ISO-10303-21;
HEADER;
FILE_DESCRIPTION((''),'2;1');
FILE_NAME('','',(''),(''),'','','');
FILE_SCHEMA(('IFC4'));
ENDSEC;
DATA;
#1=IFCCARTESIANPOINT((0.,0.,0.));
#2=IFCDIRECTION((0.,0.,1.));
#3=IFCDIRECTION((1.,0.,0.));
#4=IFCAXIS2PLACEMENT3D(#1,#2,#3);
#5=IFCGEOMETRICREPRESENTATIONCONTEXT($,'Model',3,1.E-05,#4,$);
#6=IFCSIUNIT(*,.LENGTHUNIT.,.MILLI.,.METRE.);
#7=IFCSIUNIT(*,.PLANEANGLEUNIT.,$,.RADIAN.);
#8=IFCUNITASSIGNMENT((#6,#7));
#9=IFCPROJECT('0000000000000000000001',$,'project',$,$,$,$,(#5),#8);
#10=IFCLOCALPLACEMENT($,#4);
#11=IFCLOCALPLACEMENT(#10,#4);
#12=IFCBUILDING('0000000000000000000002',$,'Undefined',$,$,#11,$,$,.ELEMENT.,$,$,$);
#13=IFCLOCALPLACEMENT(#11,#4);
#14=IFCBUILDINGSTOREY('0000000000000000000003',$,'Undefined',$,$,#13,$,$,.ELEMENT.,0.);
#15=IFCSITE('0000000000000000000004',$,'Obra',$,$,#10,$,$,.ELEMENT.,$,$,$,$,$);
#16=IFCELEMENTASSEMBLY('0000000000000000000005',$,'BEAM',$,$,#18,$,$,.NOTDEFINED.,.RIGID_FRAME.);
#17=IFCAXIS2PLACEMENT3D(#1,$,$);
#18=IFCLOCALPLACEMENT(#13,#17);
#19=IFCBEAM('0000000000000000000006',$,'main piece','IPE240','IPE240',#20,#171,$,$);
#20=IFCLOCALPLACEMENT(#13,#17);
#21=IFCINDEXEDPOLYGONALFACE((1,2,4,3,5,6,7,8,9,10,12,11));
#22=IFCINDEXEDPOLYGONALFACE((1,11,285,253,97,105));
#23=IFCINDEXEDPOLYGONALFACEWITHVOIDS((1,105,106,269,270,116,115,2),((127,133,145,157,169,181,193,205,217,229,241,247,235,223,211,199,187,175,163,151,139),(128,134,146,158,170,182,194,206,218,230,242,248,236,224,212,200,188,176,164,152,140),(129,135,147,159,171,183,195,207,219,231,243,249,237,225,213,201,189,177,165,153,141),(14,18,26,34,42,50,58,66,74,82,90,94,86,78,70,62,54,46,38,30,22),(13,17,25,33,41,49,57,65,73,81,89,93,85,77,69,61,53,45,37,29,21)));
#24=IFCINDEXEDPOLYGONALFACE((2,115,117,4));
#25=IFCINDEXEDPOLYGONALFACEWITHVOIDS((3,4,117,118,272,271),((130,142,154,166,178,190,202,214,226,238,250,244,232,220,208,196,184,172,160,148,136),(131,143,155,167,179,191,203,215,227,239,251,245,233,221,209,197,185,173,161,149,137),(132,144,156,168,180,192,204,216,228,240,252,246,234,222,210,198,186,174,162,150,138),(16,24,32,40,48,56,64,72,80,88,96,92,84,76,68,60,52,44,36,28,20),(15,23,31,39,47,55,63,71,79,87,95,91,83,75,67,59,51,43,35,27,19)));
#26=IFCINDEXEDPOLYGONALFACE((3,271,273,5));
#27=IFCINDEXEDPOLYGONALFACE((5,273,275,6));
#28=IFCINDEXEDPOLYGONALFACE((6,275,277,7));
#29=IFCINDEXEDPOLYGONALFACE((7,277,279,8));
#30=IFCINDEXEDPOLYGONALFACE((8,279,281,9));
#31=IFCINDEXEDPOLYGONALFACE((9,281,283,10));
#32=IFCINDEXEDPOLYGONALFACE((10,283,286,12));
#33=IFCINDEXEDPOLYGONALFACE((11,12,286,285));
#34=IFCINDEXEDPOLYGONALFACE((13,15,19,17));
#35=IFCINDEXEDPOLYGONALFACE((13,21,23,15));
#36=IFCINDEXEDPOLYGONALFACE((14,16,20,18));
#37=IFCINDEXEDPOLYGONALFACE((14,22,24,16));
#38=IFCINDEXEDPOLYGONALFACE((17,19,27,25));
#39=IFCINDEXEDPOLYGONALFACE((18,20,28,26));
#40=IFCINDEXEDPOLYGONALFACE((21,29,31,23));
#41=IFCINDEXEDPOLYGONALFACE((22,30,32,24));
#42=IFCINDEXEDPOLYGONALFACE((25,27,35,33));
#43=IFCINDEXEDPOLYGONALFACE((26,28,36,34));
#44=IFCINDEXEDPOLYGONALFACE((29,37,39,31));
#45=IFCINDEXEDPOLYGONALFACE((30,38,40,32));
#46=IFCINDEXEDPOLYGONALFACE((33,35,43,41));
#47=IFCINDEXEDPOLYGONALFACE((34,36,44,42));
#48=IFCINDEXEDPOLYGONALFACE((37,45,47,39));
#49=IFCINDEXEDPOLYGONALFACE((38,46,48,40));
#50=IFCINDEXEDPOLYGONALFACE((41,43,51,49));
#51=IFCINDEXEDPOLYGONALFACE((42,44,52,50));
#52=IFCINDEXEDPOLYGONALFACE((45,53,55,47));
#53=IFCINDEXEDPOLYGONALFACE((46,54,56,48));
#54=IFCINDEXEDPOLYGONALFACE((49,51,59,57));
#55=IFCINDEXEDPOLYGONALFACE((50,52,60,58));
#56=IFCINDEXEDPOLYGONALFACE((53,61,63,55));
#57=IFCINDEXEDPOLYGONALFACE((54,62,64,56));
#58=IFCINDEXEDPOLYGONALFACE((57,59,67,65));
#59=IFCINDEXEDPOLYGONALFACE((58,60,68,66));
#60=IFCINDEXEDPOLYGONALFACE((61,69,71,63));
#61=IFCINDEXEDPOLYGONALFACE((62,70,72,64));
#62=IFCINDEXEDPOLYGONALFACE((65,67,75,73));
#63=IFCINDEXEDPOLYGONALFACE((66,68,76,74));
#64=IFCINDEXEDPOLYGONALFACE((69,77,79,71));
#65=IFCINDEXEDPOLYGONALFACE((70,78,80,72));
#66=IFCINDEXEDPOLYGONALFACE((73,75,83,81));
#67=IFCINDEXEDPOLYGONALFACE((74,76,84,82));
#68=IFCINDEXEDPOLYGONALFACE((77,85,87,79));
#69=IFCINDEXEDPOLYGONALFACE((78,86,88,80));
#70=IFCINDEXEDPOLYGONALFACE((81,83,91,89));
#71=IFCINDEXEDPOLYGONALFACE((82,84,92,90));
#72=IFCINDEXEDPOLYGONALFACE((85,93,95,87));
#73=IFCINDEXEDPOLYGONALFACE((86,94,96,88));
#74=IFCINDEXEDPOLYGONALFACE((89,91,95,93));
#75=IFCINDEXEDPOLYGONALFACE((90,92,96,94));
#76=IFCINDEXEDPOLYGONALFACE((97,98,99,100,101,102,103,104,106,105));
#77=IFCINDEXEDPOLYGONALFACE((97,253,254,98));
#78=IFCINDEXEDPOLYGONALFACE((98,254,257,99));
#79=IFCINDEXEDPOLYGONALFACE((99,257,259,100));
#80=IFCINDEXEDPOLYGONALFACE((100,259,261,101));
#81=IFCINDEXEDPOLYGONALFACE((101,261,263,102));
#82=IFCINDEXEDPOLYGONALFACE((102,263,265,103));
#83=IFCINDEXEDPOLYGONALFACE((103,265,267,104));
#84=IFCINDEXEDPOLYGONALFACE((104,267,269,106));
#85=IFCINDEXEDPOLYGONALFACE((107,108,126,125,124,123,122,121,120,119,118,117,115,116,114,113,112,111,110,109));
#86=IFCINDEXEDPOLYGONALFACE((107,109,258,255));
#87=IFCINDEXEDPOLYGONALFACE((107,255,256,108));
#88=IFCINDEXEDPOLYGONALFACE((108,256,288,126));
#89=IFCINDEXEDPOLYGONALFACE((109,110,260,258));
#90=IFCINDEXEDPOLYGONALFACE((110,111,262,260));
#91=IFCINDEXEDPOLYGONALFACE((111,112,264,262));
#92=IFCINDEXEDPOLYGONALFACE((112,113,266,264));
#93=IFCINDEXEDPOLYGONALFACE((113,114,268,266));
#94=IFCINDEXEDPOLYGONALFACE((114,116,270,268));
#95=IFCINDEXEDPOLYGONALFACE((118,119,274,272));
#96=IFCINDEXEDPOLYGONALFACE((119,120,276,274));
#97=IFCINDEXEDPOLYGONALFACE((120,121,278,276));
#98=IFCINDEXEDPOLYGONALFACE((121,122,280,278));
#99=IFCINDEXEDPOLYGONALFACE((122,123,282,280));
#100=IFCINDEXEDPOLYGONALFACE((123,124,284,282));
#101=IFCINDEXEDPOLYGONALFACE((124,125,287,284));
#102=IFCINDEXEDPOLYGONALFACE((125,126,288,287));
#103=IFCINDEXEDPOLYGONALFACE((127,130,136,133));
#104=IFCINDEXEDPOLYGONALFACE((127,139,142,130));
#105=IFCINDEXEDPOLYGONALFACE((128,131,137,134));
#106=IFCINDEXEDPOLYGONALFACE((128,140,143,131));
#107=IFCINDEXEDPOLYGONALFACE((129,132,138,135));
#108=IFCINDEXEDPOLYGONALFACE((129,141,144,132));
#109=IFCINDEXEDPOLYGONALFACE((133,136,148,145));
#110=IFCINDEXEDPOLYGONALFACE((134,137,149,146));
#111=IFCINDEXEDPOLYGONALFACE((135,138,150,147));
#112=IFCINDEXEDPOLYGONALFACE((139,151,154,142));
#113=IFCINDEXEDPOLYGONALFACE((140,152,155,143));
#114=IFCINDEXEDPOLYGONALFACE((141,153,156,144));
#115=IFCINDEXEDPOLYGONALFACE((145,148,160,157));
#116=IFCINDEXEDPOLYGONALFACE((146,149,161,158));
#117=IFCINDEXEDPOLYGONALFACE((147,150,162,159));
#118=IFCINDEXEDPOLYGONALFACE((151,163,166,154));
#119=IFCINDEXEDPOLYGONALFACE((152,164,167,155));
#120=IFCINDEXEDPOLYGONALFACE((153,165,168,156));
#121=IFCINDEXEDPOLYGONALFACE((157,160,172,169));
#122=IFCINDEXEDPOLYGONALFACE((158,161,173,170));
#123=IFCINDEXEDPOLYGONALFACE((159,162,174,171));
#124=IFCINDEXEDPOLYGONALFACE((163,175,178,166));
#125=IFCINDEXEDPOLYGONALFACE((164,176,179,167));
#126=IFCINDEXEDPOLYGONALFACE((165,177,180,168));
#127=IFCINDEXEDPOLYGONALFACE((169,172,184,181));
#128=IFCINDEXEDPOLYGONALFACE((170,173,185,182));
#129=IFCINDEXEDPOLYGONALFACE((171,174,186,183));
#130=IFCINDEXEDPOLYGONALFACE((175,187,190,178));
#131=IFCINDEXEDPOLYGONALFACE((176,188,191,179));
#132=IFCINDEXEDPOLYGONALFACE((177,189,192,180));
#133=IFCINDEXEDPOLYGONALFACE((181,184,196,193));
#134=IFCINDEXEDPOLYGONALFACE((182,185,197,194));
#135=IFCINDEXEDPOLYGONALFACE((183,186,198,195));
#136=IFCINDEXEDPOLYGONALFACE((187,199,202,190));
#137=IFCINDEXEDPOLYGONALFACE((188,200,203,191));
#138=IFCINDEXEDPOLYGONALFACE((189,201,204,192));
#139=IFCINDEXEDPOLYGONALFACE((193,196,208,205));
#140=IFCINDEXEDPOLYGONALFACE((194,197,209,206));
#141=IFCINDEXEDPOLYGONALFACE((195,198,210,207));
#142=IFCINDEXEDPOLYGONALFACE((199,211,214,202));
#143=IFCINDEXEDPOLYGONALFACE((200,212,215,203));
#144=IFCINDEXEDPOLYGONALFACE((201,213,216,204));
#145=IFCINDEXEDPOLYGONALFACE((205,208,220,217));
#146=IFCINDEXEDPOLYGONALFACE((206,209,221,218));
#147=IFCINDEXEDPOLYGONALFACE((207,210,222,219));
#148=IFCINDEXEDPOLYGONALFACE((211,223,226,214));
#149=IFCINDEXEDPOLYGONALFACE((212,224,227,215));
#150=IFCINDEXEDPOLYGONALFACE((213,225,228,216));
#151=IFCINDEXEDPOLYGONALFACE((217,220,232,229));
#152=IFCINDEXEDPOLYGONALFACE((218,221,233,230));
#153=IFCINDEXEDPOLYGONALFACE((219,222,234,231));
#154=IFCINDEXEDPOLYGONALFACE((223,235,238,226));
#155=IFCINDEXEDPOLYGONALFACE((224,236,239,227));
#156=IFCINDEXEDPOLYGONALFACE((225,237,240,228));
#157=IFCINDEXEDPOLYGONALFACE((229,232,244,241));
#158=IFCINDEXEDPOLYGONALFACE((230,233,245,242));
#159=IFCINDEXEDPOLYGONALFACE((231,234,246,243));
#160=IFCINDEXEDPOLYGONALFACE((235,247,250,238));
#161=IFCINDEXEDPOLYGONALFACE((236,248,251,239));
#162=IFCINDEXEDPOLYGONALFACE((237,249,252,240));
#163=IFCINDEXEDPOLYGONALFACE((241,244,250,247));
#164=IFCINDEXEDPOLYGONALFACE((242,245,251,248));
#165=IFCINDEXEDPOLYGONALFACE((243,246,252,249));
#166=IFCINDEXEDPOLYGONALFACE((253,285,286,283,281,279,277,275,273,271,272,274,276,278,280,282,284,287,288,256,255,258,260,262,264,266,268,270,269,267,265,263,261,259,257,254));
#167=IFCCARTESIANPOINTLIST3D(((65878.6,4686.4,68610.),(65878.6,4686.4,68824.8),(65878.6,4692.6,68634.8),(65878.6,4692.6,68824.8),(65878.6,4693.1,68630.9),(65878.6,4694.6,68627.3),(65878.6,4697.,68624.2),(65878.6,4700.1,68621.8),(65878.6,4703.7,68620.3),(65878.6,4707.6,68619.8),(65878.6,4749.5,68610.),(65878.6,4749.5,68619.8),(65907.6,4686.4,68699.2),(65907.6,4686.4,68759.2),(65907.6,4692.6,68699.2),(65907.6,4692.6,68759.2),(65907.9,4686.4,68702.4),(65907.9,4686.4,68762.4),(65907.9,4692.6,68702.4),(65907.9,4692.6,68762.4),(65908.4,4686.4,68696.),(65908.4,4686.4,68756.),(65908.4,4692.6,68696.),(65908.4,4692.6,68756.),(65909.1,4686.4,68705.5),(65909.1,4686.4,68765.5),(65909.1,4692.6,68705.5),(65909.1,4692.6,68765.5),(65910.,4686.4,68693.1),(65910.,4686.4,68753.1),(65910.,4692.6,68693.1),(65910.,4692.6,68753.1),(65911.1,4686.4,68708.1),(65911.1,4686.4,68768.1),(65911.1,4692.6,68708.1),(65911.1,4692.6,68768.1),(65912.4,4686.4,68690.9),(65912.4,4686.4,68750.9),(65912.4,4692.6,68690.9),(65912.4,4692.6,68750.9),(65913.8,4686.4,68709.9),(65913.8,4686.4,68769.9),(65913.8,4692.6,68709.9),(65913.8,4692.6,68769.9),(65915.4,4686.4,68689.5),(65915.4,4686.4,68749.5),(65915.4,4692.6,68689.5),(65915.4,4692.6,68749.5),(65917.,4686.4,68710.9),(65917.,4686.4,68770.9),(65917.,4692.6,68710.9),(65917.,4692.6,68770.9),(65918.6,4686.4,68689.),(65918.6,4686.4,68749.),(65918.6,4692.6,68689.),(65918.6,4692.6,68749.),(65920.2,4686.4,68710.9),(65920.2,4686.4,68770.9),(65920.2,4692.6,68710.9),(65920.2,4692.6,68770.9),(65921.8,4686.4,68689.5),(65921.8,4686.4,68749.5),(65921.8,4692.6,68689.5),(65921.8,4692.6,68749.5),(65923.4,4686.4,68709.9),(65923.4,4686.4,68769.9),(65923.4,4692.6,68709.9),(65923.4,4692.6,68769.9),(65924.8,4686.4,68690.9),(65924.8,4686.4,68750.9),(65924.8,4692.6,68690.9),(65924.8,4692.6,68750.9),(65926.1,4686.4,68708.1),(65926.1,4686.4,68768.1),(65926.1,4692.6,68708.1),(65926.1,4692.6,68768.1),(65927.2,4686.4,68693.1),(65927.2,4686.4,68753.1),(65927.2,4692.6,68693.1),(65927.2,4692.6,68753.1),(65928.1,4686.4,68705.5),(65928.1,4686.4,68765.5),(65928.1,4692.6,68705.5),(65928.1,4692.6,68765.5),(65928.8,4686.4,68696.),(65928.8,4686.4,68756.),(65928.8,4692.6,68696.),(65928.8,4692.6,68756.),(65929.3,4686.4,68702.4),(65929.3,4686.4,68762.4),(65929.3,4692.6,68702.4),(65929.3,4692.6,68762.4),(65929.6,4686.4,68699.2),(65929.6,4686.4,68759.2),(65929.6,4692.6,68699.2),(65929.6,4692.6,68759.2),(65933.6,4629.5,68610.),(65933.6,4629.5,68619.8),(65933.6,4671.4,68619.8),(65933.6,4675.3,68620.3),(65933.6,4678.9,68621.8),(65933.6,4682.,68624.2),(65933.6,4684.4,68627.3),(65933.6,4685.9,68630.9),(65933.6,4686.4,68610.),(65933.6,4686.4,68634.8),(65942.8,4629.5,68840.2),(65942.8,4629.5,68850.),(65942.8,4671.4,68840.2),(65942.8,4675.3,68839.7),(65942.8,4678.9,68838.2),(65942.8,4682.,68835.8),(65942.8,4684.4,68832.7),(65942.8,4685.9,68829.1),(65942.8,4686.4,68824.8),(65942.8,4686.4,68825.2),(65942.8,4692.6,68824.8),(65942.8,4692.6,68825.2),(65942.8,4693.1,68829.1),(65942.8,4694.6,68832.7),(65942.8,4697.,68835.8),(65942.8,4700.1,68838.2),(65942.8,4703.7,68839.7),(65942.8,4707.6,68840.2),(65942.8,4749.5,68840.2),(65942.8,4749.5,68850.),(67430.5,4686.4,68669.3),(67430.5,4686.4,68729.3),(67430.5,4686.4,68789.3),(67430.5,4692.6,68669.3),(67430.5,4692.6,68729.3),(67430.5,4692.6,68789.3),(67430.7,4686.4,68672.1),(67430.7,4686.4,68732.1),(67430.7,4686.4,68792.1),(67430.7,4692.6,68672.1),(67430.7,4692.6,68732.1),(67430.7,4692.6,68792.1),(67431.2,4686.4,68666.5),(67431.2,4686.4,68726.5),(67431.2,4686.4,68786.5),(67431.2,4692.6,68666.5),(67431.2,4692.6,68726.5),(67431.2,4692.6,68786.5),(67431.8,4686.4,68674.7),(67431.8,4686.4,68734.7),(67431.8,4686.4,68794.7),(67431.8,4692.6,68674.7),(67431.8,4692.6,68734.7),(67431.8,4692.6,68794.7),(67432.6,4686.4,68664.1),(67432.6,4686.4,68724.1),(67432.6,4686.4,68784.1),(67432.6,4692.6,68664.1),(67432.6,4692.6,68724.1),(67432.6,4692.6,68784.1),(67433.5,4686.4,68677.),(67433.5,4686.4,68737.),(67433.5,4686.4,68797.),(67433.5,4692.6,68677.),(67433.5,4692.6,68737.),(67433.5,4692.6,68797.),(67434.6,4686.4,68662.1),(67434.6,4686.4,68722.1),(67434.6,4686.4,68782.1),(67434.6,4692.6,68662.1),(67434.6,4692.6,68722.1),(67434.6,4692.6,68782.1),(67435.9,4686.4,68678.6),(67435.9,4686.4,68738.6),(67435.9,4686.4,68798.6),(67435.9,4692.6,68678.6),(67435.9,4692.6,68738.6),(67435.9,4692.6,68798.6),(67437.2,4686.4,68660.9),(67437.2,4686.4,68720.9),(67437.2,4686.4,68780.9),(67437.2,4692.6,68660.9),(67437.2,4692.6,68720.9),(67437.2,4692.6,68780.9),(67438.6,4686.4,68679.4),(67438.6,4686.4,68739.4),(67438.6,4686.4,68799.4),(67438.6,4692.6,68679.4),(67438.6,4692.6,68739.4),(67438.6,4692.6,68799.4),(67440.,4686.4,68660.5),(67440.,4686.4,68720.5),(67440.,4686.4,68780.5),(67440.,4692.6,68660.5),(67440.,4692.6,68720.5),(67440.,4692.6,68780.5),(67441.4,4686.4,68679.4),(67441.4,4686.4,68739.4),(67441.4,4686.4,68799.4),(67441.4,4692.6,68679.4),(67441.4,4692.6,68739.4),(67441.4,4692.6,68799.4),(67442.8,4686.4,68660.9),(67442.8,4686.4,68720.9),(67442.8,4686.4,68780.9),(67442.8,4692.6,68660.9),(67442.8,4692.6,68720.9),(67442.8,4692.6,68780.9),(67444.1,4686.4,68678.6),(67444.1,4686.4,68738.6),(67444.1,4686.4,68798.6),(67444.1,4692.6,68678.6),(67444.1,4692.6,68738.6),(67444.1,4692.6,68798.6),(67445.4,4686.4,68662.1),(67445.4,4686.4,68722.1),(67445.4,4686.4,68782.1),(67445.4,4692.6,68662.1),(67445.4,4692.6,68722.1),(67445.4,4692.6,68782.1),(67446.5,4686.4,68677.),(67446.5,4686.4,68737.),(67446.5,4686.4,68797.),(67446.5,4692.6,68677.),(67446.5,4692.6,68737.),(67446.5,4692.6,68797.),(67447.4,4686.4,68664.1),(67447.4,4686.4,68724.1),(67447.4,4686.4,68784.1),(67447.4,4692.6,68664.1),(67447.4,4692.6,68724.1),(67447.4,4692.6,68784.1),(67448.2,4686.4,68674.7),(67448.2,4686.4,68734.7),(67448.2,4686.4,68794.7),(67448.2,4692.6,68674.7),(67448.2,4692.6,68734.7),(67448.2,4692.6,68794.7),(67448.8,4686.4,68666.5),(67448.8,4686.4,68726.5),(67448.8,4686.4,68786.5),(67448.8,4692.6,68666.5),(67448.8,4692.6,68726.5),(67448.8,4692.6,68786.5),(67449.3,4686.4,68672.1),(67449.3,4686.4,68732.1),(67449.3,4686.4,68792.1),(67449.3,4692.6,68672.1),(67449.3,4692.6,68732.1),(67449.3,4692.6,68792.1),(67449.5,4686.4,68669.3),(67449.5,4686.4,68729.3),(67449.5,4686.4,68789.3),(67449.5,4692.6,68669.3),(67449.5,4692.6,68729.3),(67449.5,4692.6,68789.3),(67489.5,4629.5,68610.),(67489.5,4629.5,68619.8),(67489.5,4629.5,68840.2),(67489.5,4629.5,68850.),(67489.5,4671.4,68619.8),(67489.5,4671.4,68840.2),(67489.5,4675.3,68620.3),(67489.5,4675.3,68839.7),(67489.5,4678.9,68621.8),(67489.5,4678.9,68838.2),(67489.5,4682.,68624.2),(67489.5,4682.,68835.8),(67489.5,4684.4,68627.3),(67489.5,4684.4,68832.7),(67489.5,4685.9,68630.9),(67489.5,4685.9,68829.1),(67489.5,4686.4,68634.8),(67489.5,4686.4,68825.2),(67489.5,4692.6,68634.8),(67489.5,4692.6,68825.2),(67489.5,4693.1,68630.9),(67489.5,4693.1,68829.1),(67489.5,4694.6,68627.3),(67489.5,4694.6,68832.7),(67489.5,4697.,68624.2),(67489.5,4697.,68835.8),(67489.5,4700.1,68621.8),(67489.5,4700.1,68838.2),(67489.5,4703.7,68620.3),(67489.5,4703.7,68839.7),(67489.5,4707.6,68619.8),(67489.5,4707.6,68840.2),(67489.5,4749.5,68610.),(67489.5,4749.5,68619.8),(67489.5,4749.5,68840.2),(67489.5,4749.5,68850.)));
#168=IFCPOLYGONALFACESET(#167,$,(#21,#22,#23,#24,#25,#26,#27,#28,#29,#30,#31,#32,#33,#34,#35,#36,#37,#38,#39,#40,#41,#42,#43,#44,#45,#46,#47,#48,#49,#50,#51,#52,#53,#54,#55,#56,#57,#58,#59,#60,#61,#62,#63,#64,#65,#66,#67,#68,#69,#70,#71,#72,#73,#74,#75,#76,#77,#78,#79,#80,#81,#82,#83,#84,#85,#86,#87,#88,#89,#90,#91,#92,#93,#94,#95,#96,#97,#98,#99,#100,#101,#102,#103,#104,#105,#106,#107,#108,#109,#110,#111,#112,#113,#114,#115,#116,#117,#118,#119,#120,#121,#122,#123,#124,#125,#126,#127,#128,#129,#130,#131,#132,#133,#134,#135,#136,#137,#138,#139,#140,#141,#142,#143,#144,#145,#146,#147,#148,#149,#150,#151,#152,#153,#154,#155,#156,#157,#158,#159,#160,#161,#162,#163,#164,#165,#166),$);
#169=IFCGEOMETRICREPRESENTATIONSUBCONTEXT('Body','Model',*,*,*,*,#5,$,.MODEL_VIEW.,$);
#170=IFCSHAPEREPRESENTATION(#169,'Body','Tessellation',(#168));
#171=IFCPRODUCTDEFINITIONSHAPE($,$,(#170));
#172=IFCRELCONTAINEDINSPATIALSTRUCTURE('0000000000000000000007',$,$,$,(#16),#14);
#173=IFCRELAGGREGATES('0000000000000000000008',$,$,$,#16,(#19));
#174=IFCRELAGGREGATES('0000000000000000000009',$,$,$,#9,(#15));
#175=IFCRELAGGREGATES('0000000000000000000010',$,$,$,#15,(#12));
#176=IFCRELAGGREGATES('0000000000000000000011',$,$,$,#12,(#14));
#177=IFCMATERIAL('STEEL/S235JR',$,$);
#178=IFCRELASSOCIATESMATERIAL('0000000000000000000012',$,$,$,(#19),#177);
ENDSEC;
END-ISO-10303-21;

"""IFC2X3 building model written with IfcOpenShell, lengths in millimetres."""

from ifc_helpers import new_model, si_unit, frame, origin_with_axes, origin_2d_with_axis, place, context, subcontext, project, spatial, rectangle, circle, i_section, extrude, clip, halfspace, source, transform, mapped, material, element, aggregate, save


model = new_model("IFC2X3")

# Units and contexts
model_context = context("Model", 3, precision=1e-05, world=origin_with_axes())
body_context = subcontext(model_context, "Body", "Model", "MODEL_VIEW")
ifc_project = project(units=[si_unit("LENGTHUNIT", "METRE", prefix="MILLI"), si_unit("PLANEANGLEUNIT", "RADIAN")], contexts=[model_context])

# Site, building, storey
site_placement = place(None, origin_with_axes())
site = spatial("IfcSite", under=ifc_project, at=site_placement, Name="Obra", CompositionType="ELEMENT")
building_placement = place(site_placement, origin_with_axes())
building = spatial("IfcBuilding", under=site, at=building_placement, Name="Undefined", CompositionType="ELEMENT")
storey_placement = place(building_placement, origin_with_axes())
storey = spatial("IfcBuildingStorey", under=building, at=storey_placement, Name="Undefined", CompositionType="ELEMENT", Elevation=0.0)

# Element assembly, beam, openings
ifc_material_1 = material(Name="STEEL/S235JR")
shared_shape_1 = source(origin_with_axes(), body_context, "Body", "SweptSolid", [
    extrude(circle(Radius=11.0, at=origin_2d_with_axis()), frame((0.0, -3.2, 0.0), z_axis=(0.0, 1.0, 0.0), x_axis=(1.0, 0.0, 0.0)), (0.0, 0.0, 1.0), 6.4),
])
assembly_1_placement = place(storey_placement, origin_with_axes())
assembly_1 = element("IfcElementAssembly", 1, at=assembly_1_placement, inside=storey, Name="BEAM", AssemblyPlace="NOTDEFINED", PredefinedType="RIGID_FRAME")
beam_1_placement = place(assembly_1_placement, frame((65952.4, 4689.5, 68730.0), z_axis=(0.0, 0.0, 1.0), x_axis=(1.0, 0.0, 0.0)))
beam_1 = element("IfcBeam", 2, at=beam_1_placement, material=ifc_material_1, Name="main piece", Description="IPE240", ObjectType="IPE240", context=body_context, shape_type="Clipping", body=[
    clip(clip(extrude(i_section(OverallWidth=120.0, OverallDepth=240.0, WebThickness=6.2, FlangeThickness=9.8, FilletRadius=15.0, at=origin_2d_with_axis()), frame((1754.5, 0.0, 0.0), z_axis=(-1.0, 0.0, 0.0), x_axis=(0.0, -1.0, 0.0)), (0.0, 0.0, 1.0), 1828.3), halfspace(frame((1537.1, -60.0, -120.0), z_axis=(1.0, 0.000019, 0.0), x_axis=(0.0, 0.0, 1.0)), False)), halfspace(frame((-73.8, 0.0, -220.0), z_axis=(1.0, 0.0, 0.0), x_axis=(0.0, -1.0, 0.0)), True)),
])
opening_1_placement = place(assembly_1_placement, frame((65952.4, 4689.5, 68730.0), z_axis=(0.0, 0.0, 1.0), x_axis=(1.0, 0.0, 0.0)))
element("IfcOpeningElement", 3, at=opening_1_placement, cuts=beam_1, ObjectType="Recess", context=body_context, shape_type="SweptSolid", body=[
    extrude(rectangle(XDim=65.0, YDim=300.0, at=origin_2d_with_axis()), frame((-51.3, -153.1, 109.8), z_axis=(0.0, 0.0, -1.0), x_axis=(1.0, 0.0, 0.0)), (0.0, 0.0, 1.0), 249.6),
])
opening_2_placement = place(assembly_1_placement, frame((65952.4, 4689.5, 68730.0), z_axis=(0.0, 0.0, 1.0), x_axis=(1.0, 0.0, 0.0)))
element("IfcOpeningElement", 4, at=opening_2_placement, cuts=beam_1, ObjectType="Recess", context=body_context, shape_type="SweptSolid", body=[
    extrude(rectangle(XDim=26.2, YDim=76.2, at=origin_2d_with_axis()), frame((-47.7, -61.0, 107.9), z_axis=(0.0, 1.0, 0.0), x_axis=(0.0, 0.0, -1.0)), (0.0, 0.0, 1.0), 122.0),
])
opening_3_placement = place(assembly_1_placement, frame((65878.6, 4689.5, 68850.0), z_axis=(1.0, 0.0, 0.0), x_axis=(0.0, 0.0, -1.0)))
element("IfcOpeningElement", 5, at=opening_3_placement, cuts=beam_1, ObjectType="Opening", context=body_context, shape_type="MappedRepresentation", body=[
    mapped(shared_shape_1, transform((90.0, 0.0, 40.0))),
    mapped(shared_shape_1, transform((150.0, 0.0, 40.0))),
])
shared_shape_2 = source(origin_with_axes(), body_context, "Body", "SweptSolid", [
    extrude(circle(Radius=9.5, at=origin_2d_with_axis()), frame((0.0, -3.2, 0.0), z_axis=(0.0, 1.0, 0.0), x_axis=(1.0, 0.0, 0.0)), (0.0, 0.0, 1.0), 6.4),
])
opening_4_placement = place(assembly_1_placement, frame((67490.0, 4689.5, 68850.0), z_axis=(-1.0, 0.0, 0.0), x_axis=(0.0, 0.0, -1.0)))
element("IfcOpeningElement", 6, at=opening_4_placement, cuts=beam_1, ObjectType="Opening", context=body_context, shape_type="MappedRepresentation", body=[
    mapped(shared_shape_2, transform((60.0, 0.0, 50.0))),
    mapped(shared_shape_2, transform((120.0, 0.0, 50.0))),
    mapped(shared_shape_2, transform((180.0, 0.0, 50.0))),
])
aggregate(assembly_1, [beam_1])

save(model, "model.ifc")
